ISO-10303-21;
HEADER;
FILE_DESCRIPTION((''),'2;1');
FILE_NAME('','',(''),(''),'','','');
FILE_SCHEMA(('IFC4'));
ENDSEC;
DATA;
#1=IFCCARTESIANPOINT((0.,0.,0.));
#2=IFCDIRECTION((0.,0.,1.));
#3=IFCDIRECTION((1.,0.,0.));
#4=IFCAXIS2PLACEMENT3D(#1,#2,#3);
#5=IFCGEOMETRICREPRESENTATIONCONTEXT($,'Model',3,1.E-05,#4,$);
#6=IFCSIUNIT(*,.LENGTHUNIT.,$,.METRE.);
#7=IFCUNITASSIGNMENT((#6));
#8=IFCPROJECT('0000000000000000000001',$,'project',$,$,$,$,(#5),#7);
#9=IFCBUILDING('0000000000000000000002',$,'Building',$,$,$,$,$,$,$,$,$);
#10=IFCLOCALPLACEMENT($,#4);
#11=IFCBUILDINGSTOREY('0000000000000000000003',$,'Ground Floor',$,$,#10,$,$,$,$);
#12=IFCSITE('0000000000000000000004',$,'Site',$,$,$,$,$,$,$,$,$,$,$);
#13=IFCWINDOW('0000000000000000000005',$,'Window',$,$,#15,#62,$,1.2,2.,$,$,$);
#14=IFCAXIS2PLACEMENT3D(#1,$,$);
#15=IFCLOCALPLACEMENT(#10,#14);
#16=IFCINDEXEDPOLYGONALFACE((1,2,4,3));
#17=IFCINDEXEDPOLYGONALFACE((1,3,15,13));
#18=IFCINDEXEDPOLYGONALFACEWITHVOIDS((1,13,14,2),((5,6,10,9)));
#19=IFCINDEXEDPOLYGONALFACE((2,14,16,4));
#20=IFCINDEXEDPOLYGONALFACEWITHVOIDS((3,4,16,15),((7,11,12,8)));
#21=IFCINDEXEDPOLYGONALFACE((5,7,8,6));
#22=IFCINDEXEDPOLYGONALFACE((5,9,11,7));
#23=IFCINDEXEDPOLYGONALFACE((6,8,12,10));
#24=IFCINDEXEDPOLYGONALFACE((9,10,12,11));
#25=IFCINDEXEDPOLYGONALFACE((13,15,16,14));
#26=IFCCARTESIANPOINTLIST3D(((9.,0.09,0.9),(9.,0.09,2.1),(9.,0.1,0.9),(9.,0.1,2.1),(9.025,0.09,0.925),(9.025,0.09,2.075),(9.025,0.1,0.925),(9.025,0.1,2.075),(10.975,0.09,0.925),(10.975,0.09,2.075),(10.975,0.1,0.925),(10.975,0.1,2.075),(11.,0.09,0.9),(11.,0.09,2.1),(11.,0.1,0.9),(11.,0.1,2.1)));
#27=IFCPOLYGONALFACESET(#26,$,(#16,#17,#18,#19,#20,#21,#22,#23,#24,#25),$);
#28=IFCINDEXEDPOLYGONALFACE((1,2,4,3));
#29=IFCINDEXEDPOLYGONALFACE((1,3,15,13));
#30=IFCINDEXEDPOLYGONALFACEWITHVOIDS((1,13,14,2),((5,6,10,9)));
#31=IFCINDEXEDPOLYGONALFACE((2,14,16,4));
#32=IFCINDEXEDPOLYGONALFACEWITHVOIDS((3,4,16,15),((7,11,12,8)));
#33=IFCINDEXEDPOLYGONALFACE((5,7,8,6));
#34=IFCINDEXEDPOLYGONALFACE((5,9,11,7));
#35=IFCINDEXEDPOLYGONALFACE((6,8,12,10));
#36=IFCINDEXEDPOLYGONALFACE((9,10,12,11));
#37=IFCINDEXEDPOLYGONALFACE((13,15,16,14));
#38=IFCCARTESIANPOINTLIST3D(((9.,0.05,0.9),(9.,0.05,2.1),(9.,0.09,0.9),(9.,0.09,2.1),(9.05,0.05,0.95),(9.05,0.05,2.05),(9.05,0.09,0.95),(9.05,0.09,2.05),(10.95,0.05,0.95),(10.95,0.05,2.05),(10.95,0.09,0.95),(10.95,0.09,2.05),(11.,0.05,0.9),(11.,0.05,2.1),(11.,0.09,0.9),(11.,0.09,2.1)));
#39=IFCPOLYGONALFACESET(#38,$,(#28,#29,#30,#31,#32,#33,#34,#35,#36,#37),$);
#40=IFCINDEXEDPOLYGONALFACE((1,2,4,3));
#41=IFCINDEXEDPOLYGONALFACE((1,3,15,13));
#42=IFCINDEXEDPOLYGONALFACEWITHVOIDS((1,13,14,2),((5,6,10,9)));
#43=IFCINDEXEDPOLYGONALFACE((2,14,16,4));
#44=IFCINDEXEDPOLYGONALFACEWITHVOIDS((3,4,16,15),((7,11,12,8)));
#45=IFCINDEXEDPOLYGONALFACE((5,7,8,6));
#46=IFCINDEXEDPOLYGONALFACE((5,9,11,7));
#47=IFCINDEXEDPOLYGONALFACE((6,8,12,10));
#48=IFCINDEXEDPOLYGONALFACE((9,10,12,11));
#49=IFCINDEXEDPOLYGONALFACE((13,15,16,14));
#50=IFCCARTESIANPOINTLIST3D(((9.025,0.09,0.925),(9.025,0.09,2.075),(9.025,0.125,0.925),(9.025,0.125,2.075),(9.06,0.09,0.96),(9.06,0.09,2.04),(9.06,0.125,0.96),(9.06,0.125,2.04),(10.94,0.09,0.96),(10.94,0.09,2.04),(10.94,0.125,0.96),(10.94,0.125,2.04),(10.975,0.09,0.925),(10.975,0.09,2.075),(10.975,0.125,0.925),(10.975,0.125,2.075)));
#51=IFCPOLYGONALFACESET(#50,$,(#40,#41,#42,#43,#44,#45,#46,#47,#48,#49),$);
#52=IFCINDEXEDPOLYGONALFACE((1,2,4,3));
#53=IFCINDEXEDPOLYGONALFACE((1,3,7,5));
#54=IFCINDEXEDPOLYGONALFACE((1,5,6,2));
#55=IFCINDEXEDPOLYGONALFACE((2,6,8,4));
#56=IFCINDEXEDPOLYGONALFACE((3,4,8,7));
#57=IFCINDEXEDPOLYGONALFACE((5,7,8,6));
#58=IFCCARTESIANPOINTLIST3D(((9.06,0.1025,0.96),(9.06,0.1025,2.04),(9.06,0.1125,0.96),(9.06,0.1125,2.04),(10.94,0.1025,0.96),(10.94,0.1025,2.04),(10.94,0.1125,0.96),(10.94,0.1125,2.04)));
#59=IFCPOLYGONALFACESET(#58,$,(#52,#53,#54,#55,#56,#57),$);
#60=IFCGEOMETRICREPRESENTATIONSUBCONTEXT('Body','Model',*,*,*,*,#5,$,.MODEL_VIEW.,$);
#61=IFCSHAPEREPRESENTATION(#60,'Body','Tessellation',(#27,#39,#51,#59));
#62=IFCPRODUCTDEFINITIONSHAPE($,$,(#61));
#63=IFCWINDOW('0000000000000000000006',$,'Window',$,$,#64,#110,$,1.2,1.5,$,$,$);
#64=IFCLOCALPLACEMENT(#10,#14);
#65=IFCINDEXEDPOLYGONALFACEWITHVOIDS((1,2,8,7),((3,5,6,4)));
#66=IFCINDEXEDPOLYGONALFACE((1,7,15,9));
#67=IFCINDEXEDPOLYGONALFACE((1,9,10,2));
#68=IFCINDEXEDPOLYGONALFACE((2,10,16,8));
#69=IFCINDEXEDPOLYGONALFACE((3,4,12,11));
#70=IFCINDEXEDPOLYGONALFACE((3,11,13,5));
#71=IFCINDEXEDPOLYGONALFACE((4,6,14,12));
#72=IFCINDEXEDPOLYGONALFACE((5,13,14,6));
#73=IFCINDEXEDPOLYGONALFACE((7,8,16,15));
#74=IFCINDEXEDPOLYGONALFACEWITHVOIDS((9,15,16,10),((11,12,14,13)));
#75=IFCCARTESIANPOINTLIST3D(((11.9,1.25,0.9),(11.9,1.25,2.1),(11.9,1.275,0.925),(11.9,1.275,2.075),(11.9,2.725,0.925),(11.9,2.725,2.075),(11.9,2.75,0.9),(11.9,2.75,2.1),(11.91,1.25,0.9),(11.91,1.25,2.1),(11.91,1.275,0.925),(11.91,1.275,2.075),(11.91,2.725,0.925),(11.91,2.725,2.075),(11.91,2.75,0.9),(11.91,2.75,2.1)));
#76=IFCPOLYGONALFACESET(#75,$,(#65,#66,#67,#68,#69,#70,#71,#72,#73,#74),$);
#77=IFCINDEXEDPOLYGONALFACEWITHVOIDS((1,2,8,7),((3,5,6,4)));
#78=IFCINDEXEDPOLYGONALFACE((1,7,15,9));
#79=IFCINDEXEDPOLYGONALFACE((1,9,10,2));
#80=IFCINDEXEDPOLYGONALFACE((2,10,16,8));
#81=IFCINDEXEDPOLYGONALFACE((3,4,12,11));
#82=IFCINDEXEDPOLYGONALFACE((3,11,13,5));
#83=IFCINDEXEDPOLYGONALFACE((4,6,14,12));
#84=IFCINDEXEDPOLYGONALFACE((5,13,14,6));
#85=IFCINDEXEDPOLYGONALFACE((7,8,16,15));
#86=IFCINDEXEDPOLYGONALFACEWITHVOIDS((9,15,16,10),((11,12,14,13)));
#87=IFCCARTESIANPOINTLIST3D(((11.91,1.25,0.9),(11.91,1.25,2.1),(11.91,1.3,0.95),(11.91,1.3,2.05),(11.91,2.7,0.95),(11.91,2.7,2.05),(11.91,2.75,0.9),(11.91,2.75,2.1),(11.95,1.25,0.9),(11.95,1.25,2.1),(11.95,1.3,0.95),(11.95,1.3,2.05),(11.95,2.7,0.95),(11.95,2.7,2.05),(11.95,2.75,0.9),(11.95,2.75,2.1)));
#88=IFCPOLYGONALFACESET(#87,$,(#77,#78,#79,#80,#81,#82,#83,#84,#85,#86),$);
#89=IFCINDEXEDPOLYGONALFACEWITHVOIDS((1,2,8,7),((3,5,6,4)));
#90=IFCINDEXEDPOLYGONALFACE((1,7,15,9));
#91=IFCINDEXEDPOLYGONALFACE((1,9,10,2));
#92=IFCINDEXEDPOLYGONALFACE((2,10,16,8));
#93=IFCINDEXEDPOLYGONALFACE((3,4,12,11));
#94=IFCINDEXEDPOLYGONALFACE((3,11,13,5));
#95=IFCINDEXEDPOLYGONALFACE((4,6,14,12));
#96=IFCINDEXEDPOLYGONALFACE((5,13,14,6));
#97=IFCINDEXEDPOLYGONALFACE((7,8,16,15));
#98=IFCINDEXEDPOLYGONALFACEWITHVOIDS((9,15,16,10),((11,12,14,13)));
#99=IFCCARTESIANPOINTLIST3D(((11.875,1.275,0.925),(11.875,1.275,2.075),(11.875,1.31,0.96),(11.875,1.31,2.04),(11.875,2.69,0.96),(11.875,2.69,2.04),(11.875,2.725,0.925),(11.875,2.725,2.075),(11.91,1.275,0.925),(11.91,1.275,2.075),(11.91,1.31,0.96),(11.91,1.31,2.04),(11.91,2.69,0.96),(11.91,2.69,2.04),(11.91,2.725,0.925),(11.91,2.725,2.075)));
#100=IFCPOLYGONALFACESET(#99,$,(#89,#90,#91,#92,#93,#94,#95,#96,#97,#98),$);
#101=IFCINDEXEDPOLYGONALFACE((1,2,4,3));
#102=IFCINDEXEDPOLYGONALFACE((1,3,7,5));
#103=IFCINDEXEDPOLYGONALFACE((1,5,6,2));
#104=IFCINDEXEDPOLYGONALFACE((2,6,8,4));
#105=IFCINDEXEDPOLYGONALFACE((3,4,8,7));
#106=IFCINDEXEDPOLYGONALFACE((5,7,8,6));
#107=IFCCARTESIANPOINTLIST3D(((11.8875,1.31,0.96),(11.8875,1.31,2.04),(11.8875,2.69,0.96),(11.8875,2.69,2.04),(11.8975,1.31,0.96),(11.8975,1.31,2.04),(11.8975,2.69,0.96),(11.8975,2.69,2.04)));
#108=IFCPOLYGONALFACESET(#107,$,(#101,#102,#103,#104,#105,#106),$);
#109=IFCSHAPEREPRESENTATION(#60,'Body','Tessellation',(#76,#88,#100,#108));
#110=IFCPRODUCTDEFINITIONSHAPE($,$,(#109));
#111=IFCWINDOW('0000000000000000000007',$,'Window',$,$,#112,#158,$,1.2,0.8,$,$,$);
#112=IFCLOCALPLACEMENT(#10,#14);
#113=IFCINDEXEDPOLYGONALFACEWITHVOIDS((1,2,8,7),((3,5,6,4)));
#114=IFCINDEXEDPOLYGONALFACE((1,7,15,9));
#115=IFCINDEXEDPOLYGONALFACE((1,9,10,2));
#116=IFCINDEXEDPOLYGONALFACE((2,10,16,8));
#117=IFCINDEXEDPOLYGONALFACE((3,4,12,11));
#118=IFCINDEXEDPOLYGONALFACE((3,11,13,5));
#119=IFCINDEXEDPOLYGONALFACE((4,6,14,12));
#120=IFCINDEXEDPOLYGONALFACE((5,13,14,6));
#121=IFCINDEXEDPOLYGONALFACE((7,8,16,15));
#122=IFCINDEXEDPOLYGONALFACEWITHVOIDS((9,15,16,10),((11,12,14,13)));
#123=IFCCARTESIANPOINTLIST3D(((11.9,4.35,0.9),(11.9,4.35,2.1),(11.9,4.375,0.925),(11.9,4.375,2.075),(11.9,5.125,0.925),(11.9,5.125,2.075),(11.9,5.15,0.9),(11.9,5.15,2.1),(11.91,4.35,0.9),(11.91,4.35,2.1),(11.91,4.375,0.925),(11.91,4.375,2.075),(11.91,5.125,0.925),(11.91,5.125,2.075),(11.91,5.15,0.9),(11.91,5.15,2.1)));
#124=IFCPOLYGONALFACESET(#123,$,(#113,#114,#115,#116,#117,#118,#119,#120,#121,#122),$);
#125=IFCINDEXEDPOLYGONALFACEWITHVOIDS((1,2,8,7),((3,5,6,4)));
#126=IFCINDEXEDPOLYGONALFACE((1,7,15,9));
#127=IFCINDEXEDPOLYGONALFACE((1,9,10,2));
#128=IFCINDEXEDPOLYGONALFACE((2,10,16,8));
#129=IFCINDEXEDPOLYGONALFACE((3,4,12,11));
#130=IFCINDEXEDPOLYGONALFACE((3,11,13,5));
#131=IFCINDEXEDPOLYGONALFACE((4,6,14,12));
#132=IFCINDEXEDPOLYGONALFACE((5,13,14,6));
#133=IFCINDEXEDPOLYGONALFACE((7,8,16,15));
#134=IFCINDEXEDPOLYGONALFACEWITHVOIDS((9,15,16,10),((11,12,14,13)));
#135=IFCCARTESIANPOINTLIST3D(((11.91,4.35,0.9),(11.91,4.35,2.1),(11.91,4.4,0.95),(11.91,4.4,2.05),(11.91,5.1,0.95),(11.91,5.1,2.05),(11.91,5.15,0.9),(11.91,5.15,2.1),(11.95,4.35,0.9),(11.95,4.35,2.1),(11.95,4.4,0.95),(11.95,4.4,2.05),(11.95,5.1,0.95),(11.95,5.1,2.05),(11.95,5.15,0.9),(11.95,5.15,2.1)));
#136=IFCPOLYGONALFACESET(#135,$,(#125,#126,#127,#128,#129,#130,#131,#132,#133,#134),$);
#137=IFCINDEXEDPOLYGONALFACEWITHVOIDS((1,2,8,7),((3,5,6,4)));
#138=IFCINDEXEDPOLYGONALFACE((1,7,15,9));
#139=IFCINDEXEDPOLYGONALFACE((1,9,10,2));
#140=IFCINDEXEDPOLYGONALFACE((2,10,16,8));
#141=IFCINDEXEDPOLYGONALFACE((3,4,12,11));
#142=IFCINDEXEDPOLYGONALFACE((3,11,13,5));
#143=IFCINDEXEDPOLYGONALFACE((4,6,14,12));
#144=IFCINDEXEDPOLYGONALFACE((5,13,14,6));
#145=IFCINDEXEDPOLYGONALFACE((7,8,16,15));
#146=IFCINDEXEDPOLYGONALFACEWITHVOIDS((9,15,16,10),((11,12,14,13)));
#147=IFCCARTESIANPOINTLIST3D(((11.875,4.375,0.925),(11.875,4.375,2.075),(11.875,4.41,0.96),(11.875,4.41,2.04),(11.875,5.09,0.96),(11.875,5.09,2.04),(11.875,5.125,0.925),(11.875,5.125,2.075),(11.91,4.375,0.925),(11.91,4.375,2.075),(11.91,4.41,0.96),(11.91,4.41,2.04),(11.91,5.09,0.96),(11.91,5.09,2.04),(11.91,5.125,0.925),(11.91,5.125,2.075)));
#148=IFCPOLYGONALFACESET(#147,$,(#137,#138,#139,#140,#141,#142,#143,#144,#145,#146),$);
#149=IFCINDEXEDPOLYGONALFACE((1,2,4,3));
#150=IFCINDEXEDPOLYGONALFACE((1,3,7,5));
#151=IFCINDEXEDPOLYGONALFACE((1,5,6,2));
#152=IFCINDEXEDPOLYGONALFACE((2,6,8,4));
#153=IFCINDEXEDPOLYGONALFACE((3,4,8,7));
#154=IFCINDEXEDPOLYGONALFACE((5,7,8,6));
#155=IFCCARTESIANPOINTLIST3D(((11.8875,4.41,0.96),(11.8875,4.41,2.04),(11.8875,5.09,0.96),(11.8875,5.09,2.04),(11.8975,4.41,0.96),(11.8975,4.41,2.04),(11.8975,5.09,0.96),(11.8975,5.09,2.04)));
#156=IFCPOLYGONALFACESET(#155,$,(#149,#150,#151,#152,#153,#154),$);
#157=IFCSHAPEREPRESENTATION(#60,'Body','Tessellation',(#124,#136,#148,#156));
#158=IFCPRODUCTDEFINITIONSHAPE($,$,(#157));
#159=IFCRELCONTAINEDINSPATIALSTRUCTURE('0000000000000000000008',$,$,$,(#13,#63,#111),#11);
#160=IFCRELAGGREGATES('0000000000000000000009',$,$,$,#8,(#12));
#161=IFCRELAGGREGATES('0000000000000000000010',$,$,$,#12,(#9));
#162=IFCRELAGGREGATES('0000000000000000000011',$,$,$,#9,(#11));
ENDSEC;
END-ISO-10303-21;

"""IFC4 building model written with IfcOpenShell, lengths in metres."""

from ifc_helpers import new_model, si_unit, frame, origin_with_axes, place, context, subcontext, project, spatial, line, indexed_curve, outline, extrude, element, save


model = new_model("IFC4")

# Units and contexts
model_context = context("Model", 3, precision=1e-05, world=origin_with_axes())
body_context = subcontext(model_context, "Body", "Model", "MODEL_VIEW")
ifc_project = project(units=[si_unit("LENGTHUNIT", "METRE")], contexts=[model_context])

# Site, building, storey
site = spatial("IfcSite", under=ifc_project, Name="Site")
building = spatial("IfcBuilding", under=site, Name="Building")
storey_placement = place(None, origin_with_axes())
storey = spatial("IfcBuildingStorey", under=building, at=storey_placement, Name="Ground Floor")

# Windows
window_1_placement = place(storey_placement, frame((9.0, 0.0, 0.9), z_axis=(0.0, 0.0, 1.0), x_axis=(1.0, 0.0, 0.0)))
element("IfcWindow", 1, at=window_1_placement, inside=storey, Name="Window", OverallHeight=1.2, OverallWidth=2.0, context=body_context, shape_type="SweptSolid", body=[
    extrude(outline(indexed_curve([(0.0, 0.0), (2.0, 0.0), (2.0, 1.2), (0.0, 1.2)], segments=[line(1, 2, 3, 4, 1)]), holes=[indexed_curve([(0.025, 0.025), (1.975, 0.025), (1.975, 1.175), (0.025, 1.175)], segments=[line(1, 2, 3, 4, 1)])]), frame((0.0, 0.09, 0.0), z_axis=(0.0, -1.0, 0.0), x_axis=(1.0, 0.0, 0.0)), (0.0, 0.0, -1.0), 0.01),
    extrude(outline(indexed_curve([(0.0, 0.0), (2.0, 0.0), (2.0, 1.2), (0.0, 1.2)], segments=[line(1, 2, 3, 4, 1)]), holes=[indexed_curve([(0.05, 0.05), (1.95, 0.05), (1.95, 1.15), (0.05, 1.15)], segments=[line(1, 2, 3, 4, 1)])]), frame((0.0, 0.05, 0.0), z_axis=(0.0, -1.0, 0.0), x_axis=(1.0, 0.0, 0.0)), (0.0, 0.0, -1.0), 0.04),
    extrude(outline(indexed_curve([(0.0, 0.0), (1.95, 0.0), (1.95, 1.15), (0.0, 1.15)], segments=[line(1, 2, 3, 4, 1)]), holes=[indexed_curve([(0.035, 0.035), (1.915, 0.035), (1.915, 1.115), (0.035, 1.115)], segments=[line(1, 2, 3, 4, 1)])]), frame((0.025, 0.09, 0.025), z_axis=(0.0, -1.0, 0.0), x_axis=(1.0, 0.0, 0.0)), (0.0, 0.0, -1.0), 0.035),
    extrude(outline(indexed_curve([(0.035, 0.035), (1.915, 0.035), (1.915, 1.115), (0.035, 1.115)], segments=[line(1, 2, 3, 4, 1)])), frame((0.025, 0.1025, 0.025), z_axis=(0.0, -1.0, 0.0), x_axis=(1.0, 0.0, 0.0)), (0.0, 0.0, -1.0), 0.01),
])
window_2_placement = place(storey_placement, frame((12.0, 1.25, 0.9), z_axis=(0.0, 0.0, 1.0), x_axis=(0.0, 1.0, 0.0)))
element("IfcWindow", 2, at=window_2_placement, inside=storey, Name="Window", OverallHeight=1.2, OverallWidth=1.5, context=body_context, shape_type="SweptSolid", body=[
    extrude(outline(indexed_curve([(0.0, 0.0), (1.5, 0.0), (1.5, 1.2), (0.0, 1.2)], segments=[line(1, 2, 3, 4, 1)]), holes=[indexed_curve([(0.025, 0.025), (1.475, 0.025), (1.475, 1.175), (0.025, 1.175)], segments=[line(1, 2, 3, 4, 1)])]), frame((0.0, 0.09, 0.0), z_axis=(0.0, -1.0, 0.0), x_axis=(1.0, 0.0, 0.0)), (0.0, 0.0, -1.0), 0.01),
    extrude(outline(indexed_curve([(0.0, 0.0), (1.5, 0.0), (1.5, 1.2), (0.0, 1.2)], segments=[line(1, 2, 3, 4, 1)]), holes=[indexed_curve([(0.05, 0.05), (1.45, 0.05), (1.45, 1.15), (0.05, 1.15)], segments=[line(1, 2, 3, 4, 1)])]), frame((0.0, 0.05, 0.0), z_axis=(0.0, -1.0, 0.0), x_axis=(1.0, 0.0, 0.0)), (0.0, 0.0, -1.0), 0.04),
    extrude(outline(indexed_curve([(0.0, 0.0), (1.45, 0.0), (1.45, 1.15), (0.0, 1.15)], segments=[line(1, 2, 3, 4, 1)]), holes=[indexed_curve([(0.035, 0.035), (1.415, 0.035), (1.415, 1.115), (0.035, 1.115)], segments=[line(1, 2, 3, 4, 1)])]), frame((0.025, 0.09, 0.025), z_axis=(0.0, -1.0, 0.0), x_axis=(1.0, 0.0, 0.0)), (0.0, 0.0, -1.0), 0.035),
    extrude(outline(indexed_curve([(0.035, 0.035), (1.415, 0.035), (1.415, 1.115), (0.035, 1.115)], segments=[line(1, 2, 3, 4, 1)])), frame((0.025, 0.1025, 0.025), z_axis=(0.0, -1.0, 0.0), x_axis=(1.0, 0.0, 0.0)), (0.0, 0.0, -1.0), 0.01),
])
window_3_placement = place(storey_placement, frame((12.0, 4.35, 0.9), z_axis=(0.0, 0.0, 1.0), x_axis=(0.0, 1.0, 0.0)))
element("IfcWindow", 3, at=window_3_placement, inside=storey, Name="Window", OverallHeight=1.2, OverallWidth=0.8, context=body_context, shape_type="SweptSolid", body=[
    extrude(outline(indexed_curve([(0.0, 0.0), (0.8, 0.0), (0.8, 1.2), (0.0, 1.2)], segments=[line(1, 2, 3, 4, 1)]), holes=[indexed_curve([(0.025, 0.025), (0.775, 0.025), (0.775, 1.175), (0.025, 1.175)], segments=[line(1, 2, 3, 4, 1)])]), frame((0.0, 0.09, 0.0), z_axis=(0.0, -1.0, 0.0), x_axis=(1.0, 0.0, 0.0)), (0.0, 0.0, -1.0), 0.01),
    extrude(outline(indexed_curve([(0.0, 0.0), (0.8, 0.0), (0.8, 1.2), (0.0, 1.2)], segments=[line(1, 2, 3, 4, 1)]), holes=[indexed_curve([(0.05, 0.05), (0.75, 0.05), (0.75, 1.15), (0.05, 1.15)], segments=[line(1, 2, 3, 4, 1)])]), frame((0.0, 0.05, 0.0), z_axis=(0.0, -1.0, 0.0), x_axis=(1.0, 0.0, 0.0)), (0.0, 0.0, -1.0), 0.04),
    extrude(outline(indexed_curve([(0.0, 0.0), (0.75, 0.0), (0.75, 1.15), (0.0, 1.15)], segments=[line(1, 2, 3, 4, 1)]), holes=[indexed_curve([(0.035, 0.035), (0.715, 0.035), (0.715, 1.115), (0.035, 1.115)], segments=[line(1, 2, 3, 4, 1)])]), frame((0.025, 0.09, 0.025), z_axis=(0.0, -1.0, 0.0), x_axis=(1.0, 0.0, 0.0)), (0.0, 0.0, -1.0), 0.035),
    extrude(outline(indexed_curve([(0.035, 0.035), (0.715, 0.035), (0.715, 1.115), (0.035, 1.115)], segments=[line(1, 2, 3, 4, 1)])), frame((0.025, 0.1025, 0.025), z_axis=(0.0, -1.0, 0.0), x_axis=(1.0, 0.0, 0.0)), (0.0, 0.0, -1.0), 0.01),
])

save(model, "model.ifc")
